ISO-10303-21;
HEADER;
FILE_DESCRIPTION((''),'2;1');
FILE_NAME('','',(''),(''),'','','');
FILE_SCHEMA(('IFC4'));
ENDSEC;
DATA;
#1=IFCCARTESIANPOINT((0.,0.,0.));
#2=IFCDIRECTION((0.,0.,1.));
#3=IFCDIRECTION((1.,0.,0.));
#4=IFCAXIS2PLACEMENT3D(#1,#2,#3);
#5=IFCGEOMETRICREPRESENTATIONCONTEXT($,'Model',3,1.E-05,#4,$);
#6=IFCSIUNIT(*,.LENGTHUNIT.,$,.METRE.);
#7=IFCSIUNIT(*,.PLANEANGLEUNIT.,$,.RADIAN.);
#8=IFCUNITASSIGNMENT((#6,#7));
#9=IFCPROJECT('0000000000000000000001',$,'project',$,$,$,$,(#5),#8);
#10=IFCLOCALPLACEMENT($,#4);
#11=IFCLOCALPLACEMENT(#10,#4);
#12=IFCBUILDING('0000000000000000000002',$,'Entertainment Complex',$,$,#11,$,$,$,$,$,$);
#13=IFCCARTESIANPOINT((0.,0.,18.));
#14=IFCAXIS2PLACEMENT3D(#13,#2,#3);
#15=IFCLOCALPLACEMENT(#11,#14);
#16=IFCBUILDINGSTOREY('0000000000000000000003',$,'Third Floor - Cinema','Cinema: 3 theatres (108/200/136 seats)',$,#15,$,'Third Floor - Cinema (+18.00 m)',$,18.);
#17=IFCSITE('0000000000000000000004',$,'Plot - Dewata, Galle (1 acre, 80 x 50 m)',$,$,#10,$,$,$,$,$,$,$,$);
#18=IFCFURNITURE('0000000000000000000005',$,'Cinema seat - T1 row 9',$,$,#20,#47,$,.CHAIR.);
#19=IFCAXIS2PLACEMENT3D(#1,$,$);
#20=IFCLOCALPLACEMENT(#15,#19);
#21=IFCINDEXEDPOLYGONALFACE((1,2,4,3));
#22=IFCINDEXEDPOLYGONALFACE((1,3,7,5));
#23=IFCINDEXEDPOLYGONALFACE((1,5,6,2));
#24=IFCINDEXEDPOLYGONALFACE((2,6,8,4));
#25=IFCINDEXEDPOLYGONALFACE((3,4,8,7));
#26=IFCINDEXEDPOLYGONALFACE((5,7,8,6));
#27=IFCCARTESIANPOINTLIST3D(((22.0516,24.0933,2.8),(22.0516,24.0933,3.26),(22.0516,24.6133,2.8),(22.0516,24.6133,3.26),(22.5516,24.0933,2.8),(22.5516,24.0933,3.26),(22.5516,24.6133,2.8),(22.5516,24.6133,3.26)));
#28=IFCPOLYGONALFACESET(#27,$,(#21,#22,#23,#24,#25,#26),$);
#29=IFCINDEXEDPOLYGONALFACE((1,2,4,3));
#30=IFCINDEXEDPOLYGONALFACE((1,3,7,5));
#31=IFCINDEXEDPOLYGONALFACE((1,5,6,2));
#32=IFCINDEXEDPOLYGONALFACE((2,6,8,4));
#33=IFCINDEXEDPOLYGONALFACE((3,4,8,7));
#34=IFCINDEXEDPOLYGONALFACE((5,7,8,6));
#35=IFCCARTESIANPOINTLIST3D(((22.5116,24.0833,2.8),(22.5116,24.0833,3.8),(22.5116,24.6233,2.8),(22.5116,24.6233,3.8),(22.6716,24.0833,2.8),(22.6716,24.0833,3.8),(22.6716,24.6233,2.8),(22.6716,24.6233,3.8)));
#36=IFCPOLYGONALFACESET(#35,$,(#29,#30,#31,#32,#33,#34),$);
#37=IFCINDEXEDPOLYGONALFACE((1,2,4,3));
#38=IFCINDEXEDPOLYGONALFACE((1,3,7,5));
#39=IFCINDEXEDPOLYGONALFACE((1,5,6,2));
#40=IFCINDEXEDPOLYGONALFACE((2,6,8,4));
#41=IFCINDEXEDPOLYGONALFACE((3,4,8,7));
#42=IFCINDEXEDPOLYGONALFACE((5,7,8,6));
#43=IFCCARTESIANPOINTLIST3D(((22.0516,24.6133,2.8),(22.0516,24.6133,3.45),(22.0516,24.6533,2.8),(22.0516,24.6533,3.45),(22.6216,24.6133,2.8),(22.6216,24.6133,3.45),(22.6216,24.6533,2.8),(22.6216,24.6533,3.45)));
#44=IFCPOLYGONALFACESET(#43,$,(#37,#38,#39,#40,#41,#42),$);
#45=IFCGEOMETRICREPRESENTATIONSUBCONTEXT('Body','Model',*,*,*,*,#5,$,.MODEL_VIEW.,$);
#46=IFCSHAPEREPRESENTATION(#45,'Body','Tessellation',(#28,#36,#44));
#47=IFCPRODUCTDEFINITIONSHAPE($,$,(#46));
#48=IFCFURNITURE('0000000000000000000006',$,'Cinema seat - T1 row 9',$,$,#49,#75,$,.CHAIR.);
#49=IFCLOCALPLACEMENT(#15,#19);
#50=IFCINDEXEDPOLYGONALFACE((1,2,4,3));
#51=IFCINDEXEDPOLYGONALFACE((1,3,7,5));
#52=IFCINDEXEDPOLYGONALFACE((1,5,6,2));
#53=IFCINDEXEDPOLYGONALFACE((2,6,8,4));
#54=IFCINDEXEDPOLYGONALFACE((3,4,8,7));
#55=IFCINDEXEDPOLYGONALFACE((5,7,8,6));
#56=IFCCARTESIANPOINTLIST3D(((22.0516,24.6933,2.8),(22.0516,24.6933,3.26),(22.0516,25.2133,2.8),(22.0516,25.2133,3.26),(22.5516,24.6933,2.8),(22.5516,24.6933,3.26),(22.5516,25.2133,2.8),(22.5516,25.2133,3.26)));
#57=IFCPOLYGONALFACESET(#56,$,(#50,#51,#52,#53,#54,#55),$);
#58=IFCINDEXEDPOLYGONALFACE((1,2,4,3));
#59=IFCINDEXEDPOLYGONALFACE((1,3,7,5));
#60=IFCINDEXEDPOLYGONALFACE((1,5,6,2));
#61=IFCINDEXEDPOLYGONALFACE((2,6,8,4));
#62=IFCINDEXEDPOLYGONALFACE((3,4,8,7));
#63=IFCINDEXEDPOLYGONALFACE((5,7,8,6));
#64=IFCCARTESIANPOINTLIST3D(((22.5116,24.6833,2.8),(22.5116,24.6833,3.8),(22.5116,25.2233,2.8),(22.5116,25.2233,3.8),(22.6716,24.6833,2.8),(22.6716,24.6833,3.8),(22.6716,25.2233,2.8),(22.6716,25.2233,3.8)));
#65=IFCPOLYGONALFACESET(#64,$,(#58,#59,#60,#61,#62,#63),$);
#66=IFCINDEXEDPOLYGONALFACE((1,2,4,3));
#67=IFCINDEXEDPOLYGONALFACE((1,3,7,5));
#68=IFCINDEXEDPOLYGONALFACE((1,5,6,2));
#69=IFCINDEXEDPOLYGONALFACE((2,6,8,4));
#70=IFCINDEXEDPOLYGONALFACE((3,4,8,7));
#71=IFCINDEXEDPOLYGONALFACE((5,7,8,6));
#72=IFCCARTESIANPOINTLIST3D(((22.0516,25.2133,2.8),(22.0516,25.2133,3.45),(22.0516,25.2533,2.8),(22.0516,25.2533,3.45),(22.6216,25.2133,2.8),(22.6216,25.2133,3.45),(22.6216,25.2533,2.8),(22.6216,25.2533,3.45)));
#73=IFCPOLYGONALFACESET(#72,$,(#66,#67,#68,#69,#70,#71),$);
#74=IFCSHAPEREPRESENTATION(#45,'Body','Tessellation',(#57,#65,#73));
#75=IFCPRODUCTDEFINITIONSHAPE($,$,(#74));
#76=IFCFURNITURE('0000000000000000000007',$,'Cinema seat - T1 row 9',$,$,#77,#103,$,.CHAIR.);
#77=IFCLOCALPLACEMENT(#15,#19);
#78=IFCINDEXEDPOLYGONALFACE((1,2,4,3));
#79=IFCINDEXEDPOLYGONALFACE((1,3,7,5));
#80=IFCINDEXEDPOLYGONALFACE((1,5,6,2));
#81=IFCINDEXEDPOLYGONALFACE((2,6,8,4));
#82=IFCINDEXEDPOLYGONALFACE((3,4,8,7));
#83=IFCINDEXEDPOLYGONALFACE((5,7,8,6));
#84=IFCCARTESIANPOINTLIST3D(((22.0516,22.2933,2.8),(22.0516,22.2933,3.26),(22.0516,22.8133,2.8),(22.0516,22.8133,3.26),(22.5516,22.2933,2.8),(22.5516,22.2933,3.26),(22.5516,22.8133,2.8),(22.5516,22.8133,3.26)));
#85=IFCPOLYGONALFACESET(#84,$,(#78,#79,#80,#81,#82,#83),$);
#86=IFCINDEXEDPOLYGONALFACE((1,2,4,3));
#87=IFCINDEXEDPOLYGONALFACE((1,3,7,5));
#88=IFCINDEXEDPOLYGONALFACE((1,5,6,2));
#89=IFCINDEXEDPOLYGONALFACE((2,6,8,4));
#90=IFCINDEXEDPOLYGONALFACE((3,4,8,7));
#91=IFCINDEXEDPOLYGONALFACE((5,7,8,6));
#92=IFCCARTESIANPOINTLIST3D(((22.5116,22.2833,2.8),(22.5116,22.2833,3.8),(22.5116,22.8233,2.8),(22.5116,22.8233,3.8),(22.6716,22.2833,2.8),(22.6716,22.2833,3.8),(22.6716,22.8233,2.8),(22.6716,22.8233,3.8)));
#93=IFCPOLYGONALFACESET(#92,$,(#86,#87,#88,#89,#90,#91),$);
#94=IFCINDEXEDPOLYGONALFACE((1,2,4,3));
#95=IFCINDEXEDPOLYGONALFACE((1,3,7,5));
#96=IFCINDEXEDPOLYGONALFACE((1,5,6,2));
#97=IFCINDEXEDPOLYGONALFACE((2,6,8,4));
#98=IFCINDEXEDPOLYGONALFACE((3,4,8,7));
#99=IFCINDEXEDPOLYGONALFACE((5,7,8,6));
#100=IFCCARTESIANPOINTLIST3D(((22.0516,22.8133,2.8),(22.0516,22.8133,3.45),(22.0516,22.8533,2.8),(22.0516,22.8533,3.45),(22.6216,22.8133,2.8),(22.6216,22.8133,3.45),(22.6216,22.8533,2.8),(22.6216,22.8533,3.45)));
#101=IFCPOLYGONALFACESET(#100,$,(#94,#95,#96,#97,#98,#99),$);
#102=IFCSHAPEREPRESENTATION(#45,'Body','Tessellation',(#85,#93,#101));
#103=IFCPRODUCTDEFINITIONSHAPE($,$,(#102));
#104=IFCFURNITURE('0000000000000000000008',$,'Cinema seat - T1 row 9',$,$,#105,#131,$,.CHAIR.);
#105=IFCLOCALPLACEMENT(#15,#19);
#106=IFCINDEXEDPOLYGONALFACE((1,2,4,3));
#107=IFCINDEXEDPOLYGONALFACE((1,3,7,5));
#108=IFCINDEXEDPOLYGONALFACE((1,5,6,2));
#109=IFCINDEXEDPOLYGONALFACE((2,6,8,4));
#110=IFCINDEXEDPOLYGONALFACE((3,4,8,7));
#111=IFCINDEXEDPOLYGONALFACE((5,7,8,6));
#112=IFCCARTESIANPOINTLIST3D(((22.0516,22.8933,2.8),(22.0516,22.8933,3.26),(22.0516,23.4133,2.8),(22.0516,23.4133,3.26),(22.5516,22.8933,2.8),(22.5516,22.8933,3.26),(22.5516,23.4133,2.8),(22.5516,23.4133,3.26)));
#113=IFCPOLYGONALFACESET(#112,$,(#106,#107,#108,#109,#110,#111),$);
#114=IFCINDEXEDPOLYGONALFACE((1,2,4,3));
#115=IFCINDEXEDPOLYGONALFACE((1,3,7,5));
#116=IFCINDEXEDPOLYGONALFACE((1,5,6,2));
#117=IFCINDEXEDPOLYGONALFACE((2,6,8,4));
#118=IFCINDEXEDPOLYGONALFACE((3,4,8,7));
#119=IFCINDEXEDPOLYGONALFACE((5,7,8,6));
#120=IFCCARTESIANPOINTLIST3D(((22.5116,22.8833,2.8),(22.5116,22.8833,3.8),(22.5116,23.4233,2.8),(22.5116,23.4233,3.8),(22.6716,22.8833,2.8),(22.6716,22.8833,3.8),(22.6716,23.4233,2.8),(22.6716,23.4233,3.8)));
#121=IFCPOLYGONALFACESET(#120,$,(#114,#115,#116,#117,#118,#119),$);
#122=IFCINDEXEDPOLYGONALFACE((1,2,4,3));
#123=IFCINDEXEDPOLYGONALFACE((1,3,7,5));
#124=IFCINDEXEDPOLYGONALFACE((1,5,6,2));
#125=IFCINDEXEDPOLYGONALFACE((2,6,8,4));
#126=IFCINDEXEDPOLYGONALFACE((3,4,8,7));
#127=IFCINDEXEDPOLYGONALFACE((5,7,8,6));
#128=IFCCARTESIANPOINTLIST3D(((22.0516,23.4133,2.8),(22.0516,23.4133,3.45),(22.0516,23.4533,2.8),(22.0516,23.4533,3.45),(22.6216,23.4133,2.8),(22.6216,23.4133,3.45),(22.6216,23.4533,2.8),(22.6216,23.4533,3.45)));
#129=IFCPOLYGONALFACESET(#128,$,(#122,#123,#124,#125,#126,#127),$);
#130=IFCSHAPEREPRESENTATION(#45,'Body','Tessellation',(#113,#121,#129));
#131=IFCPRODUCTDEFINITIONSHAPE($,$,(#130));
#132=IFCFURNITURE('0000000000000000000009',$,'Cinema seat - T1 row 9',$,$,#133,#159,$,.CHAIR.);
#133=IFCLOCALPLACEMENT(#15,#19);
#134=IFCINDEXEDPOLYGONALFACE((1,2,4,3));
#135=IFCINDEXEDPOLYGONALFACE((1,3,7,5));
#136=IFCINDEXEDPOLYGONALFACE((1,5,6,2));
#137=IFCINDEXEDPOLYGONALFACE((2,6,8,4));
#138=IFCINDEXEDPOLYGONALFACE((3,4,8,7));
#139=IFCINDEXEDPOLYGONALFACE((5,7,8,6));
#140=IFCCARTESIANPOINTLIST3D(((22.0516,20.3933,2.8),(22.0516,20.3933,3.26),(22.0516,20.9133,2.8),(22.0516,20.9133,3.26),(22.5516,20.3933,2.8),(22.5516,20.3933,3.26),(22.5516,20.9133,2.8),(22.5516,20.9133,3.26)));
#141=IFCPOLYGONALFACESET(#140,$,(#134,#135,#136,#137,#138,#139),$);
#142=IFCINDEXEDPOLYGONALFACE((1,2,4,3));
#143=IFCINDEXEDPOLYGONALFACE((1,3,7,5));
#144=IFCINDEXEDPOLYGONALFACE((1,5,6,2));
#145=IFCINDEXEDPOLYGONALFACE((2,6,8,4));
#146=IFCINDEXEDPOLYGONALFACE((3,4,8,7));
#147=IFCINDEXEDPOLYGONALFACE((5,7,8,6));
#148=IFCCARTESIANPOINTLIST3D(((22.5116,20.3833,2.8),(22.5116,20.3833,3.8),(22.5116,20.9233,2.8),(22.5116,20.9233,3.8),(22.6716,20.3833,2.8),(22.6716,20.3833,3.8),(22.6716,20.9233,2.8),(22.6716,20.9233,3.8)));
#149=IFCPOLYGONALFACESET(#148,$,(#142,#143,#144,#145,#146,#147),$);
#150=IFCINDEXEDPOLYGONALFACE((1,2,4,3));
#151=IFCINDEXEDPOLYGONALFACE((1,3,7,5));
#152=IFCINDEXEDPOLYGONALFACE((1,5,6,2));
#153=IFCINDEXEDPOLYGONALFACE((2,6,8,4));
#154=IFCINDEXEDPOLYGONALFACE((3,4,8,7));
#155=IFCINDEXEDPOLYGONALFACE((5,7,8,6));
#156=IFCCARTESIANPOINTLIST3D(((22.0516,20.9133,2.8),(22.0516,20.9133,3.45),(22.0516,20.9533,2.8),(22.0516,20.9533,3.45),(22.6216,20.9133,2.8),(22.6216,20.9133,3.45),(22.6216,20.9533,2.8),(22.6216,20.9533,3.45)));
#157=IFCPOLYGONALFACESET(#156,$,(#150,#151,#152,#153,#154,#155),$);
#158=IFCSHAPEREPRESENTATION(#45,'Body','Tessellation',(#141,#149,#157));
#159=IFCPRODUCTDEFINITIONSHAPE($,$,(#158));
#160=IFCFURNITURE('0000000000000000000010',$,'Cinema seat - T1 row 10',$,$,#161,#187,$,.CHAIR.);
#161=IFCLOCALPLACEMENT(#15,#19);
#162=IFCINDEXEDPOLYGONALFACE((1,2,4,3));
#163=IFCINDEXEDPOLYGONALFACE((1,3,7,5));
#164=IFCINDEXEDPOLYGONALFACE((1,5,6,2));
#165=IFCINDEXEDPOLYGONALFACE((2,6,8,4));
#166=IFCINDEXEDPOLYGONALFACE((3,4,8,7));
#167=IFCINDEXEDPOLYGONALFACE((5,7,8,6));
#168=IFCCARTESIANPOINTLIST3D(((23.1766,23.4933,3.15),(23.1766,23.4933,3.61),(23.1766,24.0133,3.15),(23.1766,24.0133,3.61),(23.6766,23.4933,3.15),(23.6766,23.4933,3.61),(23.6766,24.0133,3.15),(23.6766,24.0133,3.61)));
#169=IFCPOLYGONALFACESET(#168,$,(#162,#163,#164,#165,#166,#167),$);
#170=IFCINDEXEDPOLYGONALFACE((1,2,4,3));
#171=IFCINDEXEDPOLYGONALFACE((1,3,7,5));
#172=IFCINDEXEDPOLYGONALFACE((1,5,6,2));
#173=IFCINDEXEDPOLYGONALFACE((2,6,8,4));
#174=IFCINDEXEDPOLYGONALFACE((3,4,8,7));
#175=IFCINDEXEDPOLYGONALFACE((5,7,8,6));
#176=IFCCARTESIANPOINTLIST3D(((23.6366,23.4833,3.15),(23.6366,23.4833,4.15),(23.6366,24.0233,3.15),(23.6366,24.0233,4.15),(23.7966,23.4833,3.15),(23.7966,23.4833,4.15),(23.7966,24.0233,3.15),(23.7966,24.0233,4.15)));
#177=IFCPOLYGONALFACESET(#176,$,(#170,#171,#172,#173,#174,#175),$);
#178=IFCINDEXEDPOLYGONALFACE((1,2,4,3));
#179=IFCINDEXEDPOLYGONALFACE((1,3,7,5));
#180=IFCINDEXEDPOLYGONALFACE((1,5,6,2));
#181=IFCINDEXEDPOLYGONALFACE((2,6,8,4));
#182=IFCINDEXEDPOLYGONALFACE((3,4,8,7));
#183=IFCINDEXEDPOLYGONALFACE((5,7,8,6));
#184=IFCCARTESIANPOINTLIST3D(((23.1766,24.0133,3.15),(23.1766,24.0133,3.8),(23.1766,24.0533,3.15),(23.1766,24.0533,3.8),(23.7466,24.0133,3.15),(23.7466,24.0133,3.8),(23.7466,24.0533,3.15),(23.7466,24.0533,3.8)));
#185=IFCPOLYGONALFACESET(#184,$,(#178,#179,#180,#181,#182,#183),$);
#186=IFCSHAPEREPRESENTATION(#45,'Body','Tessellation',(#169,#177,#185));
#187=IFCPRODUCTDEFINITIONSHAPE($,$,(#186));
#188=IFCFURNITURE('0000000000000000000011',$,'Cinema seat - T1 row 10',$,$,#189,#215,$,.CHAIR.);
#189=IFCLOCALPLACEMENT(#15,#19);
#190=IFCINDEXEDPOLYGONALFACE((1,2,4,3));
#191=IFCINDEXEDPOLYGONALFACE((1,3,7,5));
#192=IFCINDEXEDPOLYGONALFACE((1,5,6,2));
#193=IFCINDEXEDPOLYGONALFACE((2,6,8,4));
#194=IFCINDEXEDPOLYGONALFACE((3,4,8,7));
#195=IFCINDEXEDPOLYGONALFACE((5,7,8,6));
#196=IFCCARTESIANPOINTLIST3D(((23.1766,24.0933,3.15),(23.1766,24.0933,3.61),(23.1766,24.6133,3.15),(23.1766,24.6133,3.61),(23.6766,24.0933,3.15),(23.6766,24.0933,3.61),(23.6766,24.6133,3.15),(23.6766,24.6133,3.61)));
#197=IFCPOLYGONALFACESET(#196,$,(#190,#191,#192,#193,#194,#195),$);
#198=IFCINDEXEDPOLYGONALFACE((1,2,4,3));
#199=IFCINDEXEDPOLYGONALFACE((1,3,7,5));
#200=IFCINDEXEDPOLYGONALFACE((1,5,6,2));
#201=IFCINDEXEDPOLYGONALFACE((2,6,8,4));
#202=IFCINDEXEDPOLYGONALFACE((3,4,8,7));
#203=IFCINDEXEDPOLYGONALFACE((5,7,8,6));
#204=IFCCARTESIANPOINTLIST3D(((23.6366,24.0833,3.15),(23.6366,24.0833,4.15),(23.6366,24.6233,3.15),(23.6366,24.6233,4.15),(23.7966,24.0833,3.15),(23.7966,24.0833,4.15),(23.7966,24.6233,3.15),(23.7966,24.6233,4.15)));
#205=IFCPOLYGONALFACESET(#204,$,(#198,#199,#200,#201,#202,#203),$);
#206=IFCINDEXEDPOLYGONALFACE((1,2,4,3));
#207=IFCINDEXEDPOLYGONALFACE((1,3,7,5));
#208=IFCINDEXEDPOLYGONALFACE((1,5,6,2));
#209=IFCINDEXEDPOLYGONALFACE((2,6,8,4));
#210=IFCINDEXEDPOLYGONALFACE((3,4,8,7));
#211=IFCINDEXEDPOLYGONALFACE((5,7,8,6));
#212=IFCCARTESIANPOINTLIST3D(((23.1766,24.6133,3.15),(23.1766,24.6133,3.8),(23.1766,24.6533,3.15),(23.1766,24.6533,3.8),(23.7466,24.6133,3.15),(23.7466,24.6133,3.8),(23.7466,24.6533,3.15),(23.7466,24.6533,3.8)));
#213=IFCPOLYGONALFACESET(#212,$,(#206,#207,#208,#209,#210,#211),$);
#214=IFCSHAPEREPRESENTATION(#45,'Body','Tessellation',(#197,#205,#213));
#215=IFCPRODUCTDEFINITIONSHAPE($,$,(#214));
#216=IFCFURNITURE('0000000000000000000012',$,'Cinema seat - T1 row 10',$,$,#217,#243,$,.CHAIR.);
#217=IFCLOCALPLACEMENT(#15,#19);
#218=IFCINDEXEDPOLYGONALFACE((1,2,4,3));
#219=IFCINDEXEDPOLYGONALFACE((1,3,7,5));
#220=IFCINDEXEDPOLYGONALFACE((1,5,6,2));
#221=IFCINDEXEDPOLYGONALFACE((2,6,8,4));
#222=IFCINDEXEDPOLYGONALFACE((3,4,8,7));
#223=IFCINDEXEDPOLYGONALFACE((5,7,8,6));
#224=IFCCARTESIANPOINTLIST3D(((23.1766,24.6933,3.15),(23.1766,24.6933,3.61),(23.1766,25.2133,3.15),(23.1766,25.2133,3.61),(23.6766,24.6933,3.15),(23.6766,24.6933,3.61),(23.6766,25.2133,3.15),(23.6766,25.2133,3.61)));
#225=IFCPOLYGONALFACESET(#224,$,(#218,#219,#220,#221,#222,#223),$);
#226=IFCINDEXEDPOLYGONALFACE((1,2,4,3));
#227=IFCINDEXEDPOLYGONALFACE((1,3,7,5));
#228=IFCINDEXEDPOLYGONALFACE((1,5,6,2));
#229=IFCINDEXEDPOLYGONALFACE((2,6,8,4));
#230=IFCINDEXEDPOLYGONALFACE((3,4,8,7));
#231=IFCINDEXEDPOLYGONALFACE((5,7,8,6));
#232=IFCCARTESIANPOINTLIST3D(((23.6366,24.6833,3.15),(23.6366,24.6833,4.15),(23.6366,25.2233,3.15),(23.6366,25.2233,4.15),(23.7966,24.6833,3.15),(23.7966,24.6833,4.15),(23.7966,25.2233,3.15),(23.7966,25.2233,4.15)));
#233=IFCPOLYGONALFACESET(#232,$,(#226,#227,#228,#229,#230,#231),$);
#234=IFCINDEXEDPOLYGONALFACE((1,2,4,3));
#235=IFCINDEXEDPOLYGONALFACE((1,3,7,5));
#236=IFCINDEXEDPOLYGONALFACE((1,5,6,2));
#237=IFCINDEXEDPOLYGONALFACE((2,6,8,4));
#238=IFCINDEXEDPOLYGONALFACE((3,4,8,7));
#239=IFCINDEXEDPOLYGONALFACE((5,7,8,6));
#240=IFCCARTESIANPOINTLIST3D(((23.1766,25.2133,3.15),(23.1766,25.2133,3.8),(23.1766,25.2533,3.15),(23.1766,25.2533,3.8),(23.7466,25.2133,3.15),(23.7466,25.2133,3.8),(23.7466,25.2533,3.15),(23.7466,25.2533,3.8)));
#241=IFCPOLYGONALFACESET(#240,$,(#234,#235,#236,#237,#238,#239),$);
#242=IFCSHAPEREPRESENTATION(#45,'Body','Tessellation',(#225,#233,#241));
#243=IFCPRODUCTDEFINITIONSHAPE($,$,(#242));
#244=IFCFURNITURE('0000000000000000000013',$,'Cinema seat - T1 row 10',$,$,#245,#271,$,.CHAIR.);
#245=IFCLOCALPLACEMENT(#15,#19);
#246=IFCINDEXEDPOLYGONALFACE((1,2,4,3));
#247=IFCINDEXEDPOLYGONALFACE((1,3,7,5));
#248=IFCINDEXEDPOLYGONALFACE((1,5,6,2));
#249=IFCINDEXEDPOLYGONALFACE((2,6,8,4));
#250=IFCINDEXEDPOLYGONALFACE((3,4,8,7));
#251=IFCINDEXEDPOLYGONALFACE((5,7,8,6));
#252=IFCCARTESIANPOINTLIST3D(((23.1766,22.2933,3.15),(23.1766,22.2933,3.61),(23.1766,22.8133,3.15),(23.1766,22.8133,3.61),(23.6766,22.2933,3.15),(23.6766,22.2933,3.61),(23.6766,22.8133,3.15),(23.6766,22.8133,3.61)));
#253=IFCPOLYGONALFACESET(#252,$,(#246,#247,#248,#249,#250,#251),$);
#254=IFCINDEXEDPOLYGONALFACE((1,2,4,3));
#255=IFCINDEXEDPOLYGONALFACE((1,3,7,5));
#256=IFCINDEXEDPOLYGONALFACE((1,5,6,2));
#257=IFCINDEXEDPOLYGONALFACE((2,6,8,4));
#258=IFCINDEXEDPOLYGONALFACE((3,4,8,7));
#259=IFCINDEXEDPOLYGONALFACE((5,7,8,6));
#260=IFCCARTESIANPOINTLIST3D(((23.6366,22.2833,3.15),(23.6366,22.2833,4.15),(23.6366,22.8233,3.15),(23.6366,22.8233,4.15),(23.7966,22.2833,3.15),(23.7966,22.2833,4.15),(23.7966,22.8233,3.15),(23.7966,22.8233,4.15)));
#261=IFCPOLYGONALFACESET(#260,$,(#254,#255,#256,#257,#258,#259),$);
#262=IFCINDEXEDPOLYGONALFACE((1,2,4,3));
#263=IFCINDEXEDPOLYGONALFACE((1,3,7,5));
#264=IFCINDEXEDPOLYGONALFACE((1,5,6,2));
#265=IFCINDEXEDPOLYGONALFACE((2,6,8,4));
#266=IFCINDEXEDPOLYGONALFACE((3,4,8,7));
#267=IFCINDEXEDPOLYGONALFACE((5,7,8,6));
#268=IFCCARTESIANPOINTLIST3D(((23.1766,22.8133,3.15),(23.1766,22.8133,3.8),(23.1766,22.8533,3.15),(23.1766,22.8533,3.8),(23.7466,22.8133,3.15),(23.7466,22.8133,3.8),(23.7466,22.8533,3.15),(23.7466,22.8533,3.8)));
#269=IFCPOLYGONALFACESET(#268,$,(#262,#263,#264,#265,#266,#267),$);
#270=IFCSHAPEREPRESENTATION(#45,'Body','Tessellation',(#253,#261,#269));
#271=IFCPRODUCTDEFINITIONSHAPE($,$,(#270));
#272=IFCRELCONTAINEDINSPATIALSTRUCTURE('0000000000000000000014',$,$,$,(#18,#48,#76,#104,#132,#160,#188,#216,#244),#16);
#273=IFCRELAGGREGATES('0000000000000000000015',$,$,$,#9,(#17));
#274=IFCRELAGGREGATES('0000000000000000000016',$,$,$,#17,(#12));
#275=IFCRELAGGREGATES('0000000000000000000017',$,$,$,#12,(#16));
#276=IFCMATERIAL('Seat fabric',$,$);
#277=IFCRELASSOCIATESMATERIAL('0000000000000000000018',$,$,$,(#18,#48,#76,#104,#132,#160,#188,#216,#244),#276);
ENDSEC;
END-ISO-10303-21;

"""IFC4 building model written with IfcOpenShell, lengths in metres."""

from ifc_helpers import new_model, si_unit, frame, origin_with_axes, place, context, subcontext, project, spatial, polyline, outline, extrude, material, element, save


model = new_model("IFC4")

# Units and contexts
model_context = context("Model", 3, precision=1e-05, world=origin_with_axes())
body_context = subcontext(model_context, "Body", "Model", "MODEL_VIEW")
ifc_project = project(units=[si_unit("LENGTHUNIT", "METRE"), si_unit("PLANEANGLEUNIT", "RADIAN")], contexts=[model_context])

# Site, building, storey
site_placement = place(None, origin_with_axes())
site = spatial("IfcSite", under=ifc_project, at=site_placement, Name="Plot - Dewata, Galle (1 acre, 80 x 50 m)")
building_placement = place(site_placement, origin_with_axes())
building = spatial("IfcBuilding", under=site, at=building_placement, Name="Entertainment Complex")
storey_placement = place(building_placement, frame((0.0, 0.0, 18.0), z_axis=(0.0, 0.0, 1.0), x_axis=(1.0, 0.0, 0.0)))
storey = spatial("IfcBuildingStorey", under=building, at=storey_placement, Name="Third Floor - Cinema", Description="Cinema: 3 theatres (108/200/136 seats)", LongName="Third Floor - Cinema (+18.00 m)", Elevation=18.0)

# Furniture
ifc_material_1 = material(Name="Seat fabric")
for number, where, z_axis, x_axis, name in (
    (1, (22.6716, 24.3533, 2.8), (0.0, 0.0, 1.0), (1.0, 0.0, 0.0), "Cinema seat - T1 row 9"),
    (2, (22.6716, 24.9533, 2.8), (0.0, 0.0, 1.0), (1.0, 0.0, 0.0), "Cinema seat - T1 row 9"),
    (3, (22.6716, 22.5533, 2.8), (0.0, 0.0, 1.0), (1.0, 0.0, 0.0), "Cinema seat - T1 row 9"),
    (4, (22.6716, 23.1533, 2.8), (0.0, 0.0, 1.0), (1.0, 0.0, 0.0), "Cinema seat - T1 row 9"),
    (5, (22.6716, 20.6533, 2.8), (0.0, 0.0, 1.0), (1.0, 0.0, 0.0), "Cinema seat - T1 row 9"),
    (6, (23.7966, 23.7533, 3.15), (0.0, 0.0, 1.0), (1.0, 0.0, 0.0), "Cinema seat - T1 row 10"),
    (7, (23.7966, 24.3533, 3.15), (0.0, 0.0, 1.0), (1.0, 0.0, 0.0), "Cinema seat - T1 row 10"),
    (8, (23.7966, 24.9533, 3.15), (0.0, 0.0, 1.0), (1.0, 0.0, 0.0), "Cinema seat - T1 row 10"),
    (9, (23.7966, 22.5533, 3.15), (0.0, 0.0, 1.0), (1.0, 0.0, 0.0), "Cinema seat - T1 row 10"),
):
    element("IfcFurniture", number, at=place(storey_placement, frame(where, z_axis=z_axis, x_axis=x_axis)), inside=storey, material=ifc_material_1, Name=name, PredefinedType="CHAIR", context=body_context, shape_type="SweptSolid", body=[
        extrude(outline(polyline([(-0.62, -0.26), (-0.12, -0.26), (-0.12, 0.26), (-0.62, 0.26), (-0.62, -0.26)])), origin_with_axes(), (0.0, 0.0, 1.0), 0.46),
        extrude(outline(polyline([(-0.16, -0.27), (0.0, -0.27), (0.0, 0.27), (-0.16, 0.27), (-0.16, -0.27)])), origin_with_axes(), (0.0, 0.0, 1.0), 1.0),
        extrude(outline(polyline([(-0.62, 0.26), (-0.05, 0.26), (-0.05, 0.3), (-0.62, 0.3), (-0.62, 0.26)])), origin_with_axes(), (0.0, 0.0, 1.0), 0.65),
    ])

save(model, "model.ifc")
